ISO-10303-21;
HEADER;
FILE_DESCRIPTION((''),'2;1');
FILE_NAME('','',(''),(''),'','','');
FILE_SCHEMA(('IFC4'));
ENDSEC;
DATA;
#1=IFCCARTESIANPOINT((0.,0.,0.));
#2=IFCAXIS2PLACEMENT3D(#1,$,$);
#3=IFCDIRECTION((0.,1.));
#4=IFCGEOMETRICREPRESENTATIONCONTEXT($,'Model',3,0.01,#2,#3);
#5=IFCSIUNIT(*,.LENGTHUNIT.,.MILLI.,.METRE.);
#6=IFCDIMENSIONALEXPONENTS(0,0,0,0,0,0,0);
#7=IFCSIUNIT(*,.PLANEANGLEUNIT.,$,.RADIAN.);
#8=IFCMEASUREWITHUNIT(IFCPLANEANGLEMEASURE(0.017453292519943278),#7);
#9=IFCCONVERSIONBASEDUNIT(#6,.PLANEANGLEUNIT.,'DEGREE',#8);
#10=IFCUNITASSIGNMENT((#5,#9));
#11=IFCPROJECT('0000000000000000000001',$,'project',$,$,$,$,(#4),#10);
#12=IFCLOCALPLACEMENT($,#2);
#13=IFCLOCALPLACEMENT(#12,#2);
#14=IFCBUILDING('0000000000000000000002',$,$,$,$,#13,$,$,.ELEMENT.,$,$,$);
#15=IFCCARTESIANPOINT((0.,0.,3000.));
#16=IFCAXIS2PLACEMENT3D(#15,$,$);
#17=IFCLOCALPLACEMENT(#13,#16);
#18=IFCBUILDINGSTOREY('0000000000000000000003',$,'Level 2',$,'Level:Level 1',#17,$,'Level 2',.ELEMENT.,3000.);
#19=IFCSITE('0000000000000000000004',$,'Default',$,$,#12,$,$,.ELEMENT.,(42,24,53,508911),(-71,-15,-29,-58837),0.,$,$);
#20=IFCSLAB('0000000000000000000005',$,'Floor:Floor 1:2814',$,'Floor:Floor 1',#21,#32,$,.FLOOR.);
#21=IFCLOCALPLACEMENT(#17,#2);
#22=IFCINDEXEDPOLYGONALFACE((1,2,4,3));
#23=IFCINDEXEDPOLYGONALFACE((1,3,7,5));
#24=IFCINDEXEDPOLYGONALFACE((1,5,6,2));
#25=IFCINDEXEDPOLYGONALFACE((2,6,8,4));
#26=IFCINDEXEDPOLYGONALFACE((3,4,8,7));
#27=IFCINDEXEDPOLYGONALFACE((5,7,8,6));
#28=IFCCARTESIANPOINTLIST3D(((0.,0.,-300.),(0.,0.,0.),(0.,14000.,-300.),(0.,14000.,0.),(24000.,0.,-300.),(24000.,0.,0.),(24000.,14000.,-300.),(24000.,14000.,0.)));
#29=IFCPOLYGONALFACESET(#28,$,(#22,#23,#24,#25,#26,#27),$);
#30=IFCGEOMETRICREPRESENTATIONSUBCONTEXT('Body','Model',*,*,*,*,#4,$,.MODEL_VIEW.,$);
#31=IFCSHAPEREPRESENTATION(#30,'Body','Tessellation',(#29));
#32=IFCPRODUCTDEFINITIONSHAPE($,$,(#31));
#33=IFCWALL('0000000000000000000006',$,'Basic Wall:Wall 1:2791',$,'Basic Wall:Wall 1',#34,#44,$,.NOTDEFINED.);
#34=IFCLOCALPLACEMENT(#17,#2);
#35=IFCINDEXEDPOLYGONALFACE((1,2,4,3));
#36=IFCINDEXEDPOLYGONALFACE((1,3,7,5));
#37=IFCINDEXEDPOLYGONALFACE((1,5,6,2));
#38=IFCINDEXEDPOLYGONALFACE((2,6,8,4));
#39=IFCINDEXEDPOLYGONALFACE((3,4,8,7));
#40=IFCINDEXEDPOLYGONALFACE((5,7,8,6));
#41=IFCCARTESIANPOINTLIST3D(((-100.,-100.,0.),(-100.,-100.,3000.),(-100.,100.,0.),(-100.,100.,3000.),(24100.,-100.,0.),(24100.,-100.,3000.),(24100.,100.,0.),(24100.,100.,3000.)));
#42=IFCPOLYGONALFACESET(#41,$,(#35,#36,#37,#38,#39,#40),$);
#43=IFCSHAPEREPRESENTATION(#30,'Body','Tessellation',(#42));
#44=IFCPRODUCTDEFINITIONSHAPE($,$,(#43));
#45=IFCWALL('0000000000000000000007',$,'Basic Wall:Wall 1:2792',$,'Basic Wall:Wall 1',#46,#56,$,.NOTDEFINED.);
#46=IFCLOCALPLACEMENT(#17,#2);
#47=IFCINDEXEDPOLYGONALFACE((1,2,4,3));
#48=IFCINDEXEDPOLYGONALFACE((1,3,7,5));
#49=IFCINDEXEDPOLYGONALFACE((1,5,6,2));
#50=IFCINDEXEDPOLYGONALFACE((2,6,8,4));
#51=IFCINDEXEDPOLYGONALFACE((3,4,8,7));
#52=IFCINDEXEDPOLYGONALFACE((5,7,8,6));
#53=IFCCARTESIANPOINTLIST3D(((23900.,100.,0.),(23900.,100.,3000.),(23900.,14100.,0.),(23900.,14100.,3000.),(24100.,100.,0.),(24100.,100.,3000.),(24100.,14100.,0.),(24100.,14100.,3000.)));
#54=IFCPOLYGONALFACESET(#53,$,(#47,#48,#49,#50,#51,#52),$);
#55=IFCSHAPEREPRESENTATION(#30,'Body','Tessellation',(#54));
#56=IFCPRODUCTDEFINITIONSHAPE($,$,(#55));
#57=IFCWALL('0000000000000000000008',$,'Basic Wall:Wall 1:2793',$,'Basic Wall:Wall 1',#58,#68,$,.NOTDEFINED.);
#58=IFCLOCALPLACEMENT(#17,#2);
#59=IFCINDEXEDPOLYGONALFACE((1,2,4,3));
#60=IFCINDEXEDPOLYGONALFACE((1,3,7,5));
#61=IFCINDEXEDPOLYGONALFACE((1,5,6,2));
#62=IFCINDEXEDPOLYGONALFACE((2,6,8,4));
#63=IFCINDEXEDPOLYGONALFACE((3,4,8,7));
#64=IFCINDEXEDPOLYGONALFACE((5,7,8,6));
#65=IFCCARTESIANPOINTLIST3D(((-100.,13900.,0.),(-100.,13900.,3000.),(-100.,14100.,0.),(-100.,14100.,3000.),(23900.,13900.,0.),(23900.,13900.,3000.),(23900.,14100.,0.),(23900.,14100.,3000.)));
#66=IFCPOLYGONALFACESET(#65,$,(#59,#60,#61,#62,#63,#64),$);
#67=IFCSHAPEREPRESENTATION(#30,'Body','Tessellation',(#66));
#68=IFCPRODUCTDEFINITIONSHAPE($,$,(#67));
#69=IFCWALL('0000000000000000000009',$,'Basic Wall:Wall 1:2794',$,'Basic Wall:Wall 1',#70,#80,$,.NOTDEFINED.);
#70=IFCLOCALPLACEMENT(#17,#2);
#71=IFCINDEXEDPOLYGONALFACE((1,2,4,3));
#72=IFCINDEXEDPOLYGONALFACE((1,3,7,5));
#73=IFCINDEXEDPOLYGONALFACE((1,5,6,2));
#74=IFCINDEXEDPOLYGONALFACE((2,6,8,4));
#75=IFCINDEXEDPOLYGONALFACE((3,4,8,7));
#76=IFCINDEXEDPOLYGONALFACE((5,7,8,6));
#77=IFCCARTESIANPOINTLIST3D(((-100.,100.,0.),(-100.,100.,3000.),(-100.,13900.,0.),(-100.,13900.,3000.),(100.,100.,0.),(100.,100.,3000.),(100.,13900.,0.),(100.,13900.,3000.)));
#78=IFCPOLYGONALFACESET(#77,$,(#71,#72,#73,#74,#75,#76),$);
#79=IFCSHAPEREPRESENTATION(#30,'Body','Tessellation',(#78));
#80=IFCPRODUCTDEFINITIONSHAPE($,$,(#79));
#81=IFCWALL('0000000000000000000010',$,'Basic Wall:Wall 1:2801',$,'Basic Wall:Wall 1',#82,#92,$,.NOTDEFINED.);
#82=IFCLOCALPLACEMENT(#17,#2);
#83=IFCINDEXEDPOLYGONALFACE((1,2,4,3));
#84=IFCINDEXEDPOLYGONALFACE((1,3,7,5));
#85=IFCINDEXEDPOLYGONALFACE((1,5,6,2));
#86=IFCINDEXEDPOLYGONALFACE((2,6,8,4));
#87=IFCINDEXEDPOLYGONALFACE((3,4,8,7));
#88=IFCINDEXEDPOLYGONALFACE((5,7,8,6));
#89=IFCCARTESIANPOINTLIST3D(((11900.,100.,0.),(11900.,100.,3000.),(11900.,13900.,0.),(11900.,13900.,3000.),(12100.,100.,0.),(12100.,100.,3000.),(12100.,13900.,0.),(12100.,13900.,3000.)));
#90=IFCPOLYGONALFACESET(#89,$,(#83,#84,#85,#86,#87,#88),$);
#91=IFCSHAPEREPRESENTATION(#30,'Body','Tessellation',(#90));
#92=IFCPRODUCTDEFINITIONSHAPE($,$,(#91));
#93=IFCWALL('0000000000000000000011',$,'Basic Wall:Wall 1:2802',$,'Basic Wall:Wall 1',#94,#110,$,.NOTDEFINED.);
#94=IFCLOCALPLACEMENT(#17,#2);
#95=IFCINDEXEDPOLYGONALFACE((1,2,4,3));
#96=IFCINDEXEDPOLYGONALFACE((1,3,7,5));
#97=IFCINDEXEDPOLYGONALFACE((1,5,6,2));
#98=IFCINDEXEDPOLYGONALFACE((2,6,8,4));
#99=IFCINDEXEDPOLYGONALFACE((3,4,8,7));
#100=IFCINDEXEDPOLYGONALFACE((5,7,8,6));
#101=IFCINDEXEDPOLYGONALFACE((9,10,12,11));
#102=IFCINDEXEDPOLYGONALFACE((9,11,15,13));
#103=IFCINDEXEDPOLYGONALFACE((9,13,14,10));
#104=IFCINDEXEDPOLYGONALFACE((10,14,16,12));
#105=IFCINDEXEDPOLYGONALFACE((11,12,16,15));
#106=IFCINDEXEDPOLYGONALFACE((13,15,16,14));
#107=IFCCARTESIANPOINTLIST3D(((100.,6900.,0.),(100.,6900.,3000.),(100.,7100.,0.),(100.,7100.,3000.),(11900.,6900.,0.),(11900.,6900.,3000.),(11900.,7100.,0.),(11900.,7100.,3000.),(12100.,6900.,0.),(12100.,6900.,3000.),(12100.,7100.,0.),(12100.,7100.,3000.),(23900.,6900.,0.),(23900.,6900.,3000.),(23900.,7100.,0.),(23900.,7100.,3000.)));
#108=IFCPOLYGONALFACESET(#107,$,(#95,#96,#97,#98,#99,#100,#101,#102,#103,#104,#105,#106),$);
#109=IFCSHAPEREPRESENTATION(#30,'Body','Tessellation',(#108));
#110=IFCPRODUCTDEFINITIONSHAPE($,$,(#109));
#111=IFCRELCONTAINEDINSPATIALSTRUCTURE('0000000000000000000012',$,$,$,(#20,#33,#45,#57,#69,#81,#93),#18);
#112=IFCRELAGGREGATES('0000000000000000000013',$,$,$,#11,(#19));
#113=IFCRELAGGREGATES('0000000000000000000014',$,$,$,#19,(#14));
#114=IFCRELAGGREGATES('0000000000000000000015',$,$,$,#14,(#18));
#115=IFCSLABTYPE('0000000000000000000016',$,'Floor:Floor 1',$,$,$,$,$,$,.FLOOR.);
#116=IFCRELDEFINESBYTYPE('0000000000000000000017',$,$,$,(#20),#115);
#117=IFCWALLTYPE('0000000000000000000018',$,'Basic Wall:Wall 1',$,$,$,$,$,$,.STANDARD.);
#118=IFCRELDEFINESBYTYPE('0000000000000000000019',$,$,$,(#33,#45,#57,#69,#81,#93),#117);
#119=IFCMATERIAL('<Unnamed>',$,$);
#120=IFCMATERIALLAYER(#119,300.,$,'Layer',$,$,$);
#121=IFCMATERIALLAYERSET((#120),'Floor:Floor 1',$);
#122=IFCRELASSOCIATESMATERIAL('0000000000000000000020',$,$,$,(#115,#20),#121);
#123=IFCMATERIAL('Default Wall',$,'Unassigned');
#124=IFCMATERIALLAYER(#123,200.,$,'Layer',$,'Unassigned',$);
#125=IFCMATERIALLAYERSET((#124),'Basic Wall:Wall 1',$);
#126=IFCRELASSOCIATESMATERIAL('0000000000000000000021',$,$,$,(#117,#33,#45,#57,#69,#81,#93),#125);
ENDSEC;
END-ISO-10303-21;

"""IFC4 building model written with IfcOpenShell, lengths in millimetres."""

from ifc_helpers import new_model, entity, si_unit, converted_unit, direction, frame, frame_2d, origin, origin_2d_with_axis, place, context, subcontext, project, spatial, rectangle, extrude, material, layer, layer_set, layer_usage, type_object, element, save


model = new_model("IFC4")

# Units and contexts
model_context = context("Model", 3, precision=0.01, world=origin(), true_north=direction((0.0, 1.0)))
body_context = subcontext(model_context, "Body", "Model", "MODEL_VIEW")
ifc_project = project(units=[si_unit("LENGTHUNIT", "METRE", prefix="MILLI"), converted_unit("PLANEANGLEUNIT", "DEGREE", entity("IfcPlaneAngleMeasure", 0.017453292519943278), si_unit("PLANEANGLEUNIT", "RADIAN"), dimensions=[0, 0, 0, 0, 0, 0, 0])], contexts=[model_context])

# Site, building, storey
site_placement = place(None, origin())
site = spatial("IfcSite", under=ifc_project, at=site_placement, Name="Default", CompositionType="ELEMENT", RefLatitude=(42, 24, 53, 508911), RefLongitude=(-71, -15, -29, -58837), RefElevation=0.0)
building_placement = place(site_placement, origin())
building = spatial("IfcBuilding", under=site, at=building_placement, CompositionType="ELEMENT")
storey_placement = place(building_placement, frame((0.0, 0.0, 3000.0)))
storey = spatial("IfcBuildingStorey", under=building, at=storey_placement, Name="Level 2", ObjectType="Level:Level 1", LongName="Level 2", CompositionType="ELEMENT", Elevation=3000.0)

# Slab
ifc_material_1 = material(Name="<Unnamed>")
ifc_layer_1 = layer(ifc_material_1, 300.0, Name="Layer")
ifc_layer_set_1 = layer_set([ifc_layer_1], Name="Floor:Floor 1")
ifc_layer_usage_1 = layer_usage(ifc_layer_set_1, "AXIS3", "POSITIVE", 0.0)
slab_type = type_object("IfcSlabType", Name="Floor:Floor 1", PredefinedType="FLOOR", material=ifc_layer_set_1)
slab_placement = place(storey_placement, origin())
element("IfcSlab", 1, at=slab_placement, inside=storey, type_object=slab_type, material=ifc_layer_usage_1, Name="Floor:Floor 1:2814", ObjectType="Floor:Floor 1", PredefinedType="FLOOR", context=body_context, shape_type="SweptSolid", body=[
    extrude(rectangle(XDim=14000.0, YDim=24000.0, at=origin_2d_with_axis()), frame((12000.0, 7000.0, 0.0), z_axis=(0.0, 0.0, -1.0), x_axis=(0.0, 1.0, 0.0)), (0.0, 0.0, 1.0), 300.0),
])

# Walls
ifc_material_2 = material(Name="Default Wall", Category="Unassigned")
ifc_layer_2 = layer(ifc_material_2, 200.0, Name="Layer", Category="Unassigned")
ifc_layer_set_2 = layer_set([ifc_layer_2], Name="Basic Wall:Wall 1")
ifc_layer_usage_2 = layer_usage(ifc_layer_set_2, "AXIS2", "NEGATIVE", 100.0)
wall_type = type_object("IfcWallType", Name="Basic Wall:Wall 1", PredefinedType="STANDARD", material=ifc_layer_set_2)
wall_1_placement = place(storey_placement, frame((-100.0, 0.0, 0.0)))
element("IfcWall", 2, at=wall_1_placement, inside=storey, type_object=wall_type, material=ifc_layer_usage_2, Name="Basic Wall:Wall 1:2791", ObjectType="Basic Wall:Wall 1", PredefinedType="NOTDEFINED", context=body_context, shape_type="SweptSolid", body=[
    extrude(rectangle(XDim=24200.0, YDim=200.0, at=frame_2d((12100.0, 0.0), x_axis=(-1.0, 0.0))), origin(), (0.0, 0.0, 1.0), 3000.0),
])
ifc_layer_usage_3 = layer_usage(ifc_layer_set_2, "AXIS2", "NEGATIVE", 100.0)
wall_2_placement = place(storey_placement, frame((24000.0, 100.0, 0.0), z_axis=(0.0, 0.0, 1.0), x_axis=(0.0, 1.0, 0.0)))
element("IfcWall", 3, at=wall_2_placement, inside=storey, type_object=wall_type, material=ifc_layer_usage_3, Name="Basic Wall:Wall 1:2792", ObjectType="Basic Wall:Wall 1", PredefinedType="NOTDEFINED", context=body_context, shape_type="SweptSolid", body=[
    extrude(rectangle(XDim=14000.0, YDim=200.0, at=frame_2d((7000.0, 0.0), x_axis=(-1.0, 0.0))), origin(), (0.0, 0.0, 1.0), 3000.0),
])
ifc_layer_usage_4 = layer_usage(ifc_layer_set_2, "AXIS2", "NEGATIVE", 100.0)
wall_3_placement = place(storey_placement, frame((23900.0, 14000.0, 0.0), z_axis=(0.0, 0.0, 1.0), x_axis=(-1.0, 0.0, 0.0)))
element("IfcWall", 4, at=wall_3_placement, inside=storey, type_object=wall_type, material=ifc_layer_usage_4, Name="Basic Wall:Wall 1:2793", ObjectType="Basic Wall:Wall 1", PredefinedType="NOTDEFINED", context=body_context, shape_type="SweptSolid", body=[
    extrude(rectangle(XDim=24000.0, YDim=200.0, at=frame_2d((12000.0, 0.0), x_axis=(-1.0, 0.0))), origin(), (0.0, 0.0, 1.0), 3000.0),
])
ifc_layer_usage_5 = layer_usage(ifc_layer_set_2, "AXIS2", "NEGATIVE", 100.0)
wall_4_placement = place(storey_placement, frame((0.0, 13900.0, 0.0), z_axis=(0.0, 0.0, 1.0), x_axis=(0.0, -1.0, 0.0)))
element("IfcWall", 5, at=wall_4_placement, inside=storey, type_object=wall_type, material=ifc_layer_usage_5, Name="Basic Wall:Wall 1:2794", ObjectType="Basic Wall:Wall 1", PredefinedType="NOTDEFINED", context=body_context, shape_type="SweptSolid", body=[
    extrude(rectangle(XDim=13800.0, YDim=200.0, at=frame_2d((6900.0, 0.0), x_axis=(-1.0, 0.0))), origin(), (0.0, 0.0, 1.0), 3000.0),
])
ifc_layer_usage_6 = layer_usage(ifc_layer_set_2, "AXIS2", "NEGATIVE", 100.0)
wall_5_placement = place(storey_placement, frame((12000.0, 100.0, 0.0), z_axis=(0.0, 0.0, 1.0), x_axis=(0.0, 1.0, 0.0)))
element("IfcWall", 6, at=wall_5_placement, inside=storey, type_object=wall_type, material=ifc_layer_usage_6, Name="Basic Wall:Wall 1:2801", ObjectType="Basic Wall:Wall 1", PredefinedType="NOTDEFINED", context=body_context, shape_type="SweptSolid", body=[
    extrude(rectangle(XDim=13800.0, YDim=200.0, at=frame_2d((6900.0, 0.0), x_axis=(-1.0, 0.0))), origin(), (0.0, 0.0, 1.0), 3000.0),
])

# Wall, opening
ifc_layer_usage_7 = layer_usage(ifc_layer_set_2, "AXIS2", "NEGATIVE", 100.0)
wall_6_placement = place(storey_placement, frame((100.0, 7000.0, 0.0)))
wall_6 = element("IfcWall", 7, at=wall_6_placement, inside=storey, type_object=wall_type, material=ifc_layer_usage_7, Name="Basic Wall:Wall 1:2802", ObjectType="Basic Wall:Wall 1", PredefinedType="NOTDEFINED", context=body_context, shape_type="SweptSolid", body=[
    extrude(rectangle(XDim=23800.0, YDim=200.0, at=frame_2d((11900.0, 0.0), x_axis=(-1.0, 0.0))), origin(), (0.0, 0.0, 1.0), 3000.0),
])
opening_placement = place(storey_placement, frame((100.0, 7000.0, 0.0)))
element("IfcOpeningElement", 8, at=opening_placement, cuts=wall_6, PredefinedType="OPENING", context=body_context, shape_type="SweptSolid", body=[
    extrude(rectangle(XDim=3000.0, YDim=200.0, at=frame_2d((0.0, 0.0), x_axis=(1.0, 0.0))), frame((11800.0, 0.0, 1500.0), z_axis=(1.0, 0.0, 0.0), x_axis=(0.0, 0.0, -1.0)), (0.0, 0.0, 1.0), 200.0),
])

save(model, "model.ifc")
